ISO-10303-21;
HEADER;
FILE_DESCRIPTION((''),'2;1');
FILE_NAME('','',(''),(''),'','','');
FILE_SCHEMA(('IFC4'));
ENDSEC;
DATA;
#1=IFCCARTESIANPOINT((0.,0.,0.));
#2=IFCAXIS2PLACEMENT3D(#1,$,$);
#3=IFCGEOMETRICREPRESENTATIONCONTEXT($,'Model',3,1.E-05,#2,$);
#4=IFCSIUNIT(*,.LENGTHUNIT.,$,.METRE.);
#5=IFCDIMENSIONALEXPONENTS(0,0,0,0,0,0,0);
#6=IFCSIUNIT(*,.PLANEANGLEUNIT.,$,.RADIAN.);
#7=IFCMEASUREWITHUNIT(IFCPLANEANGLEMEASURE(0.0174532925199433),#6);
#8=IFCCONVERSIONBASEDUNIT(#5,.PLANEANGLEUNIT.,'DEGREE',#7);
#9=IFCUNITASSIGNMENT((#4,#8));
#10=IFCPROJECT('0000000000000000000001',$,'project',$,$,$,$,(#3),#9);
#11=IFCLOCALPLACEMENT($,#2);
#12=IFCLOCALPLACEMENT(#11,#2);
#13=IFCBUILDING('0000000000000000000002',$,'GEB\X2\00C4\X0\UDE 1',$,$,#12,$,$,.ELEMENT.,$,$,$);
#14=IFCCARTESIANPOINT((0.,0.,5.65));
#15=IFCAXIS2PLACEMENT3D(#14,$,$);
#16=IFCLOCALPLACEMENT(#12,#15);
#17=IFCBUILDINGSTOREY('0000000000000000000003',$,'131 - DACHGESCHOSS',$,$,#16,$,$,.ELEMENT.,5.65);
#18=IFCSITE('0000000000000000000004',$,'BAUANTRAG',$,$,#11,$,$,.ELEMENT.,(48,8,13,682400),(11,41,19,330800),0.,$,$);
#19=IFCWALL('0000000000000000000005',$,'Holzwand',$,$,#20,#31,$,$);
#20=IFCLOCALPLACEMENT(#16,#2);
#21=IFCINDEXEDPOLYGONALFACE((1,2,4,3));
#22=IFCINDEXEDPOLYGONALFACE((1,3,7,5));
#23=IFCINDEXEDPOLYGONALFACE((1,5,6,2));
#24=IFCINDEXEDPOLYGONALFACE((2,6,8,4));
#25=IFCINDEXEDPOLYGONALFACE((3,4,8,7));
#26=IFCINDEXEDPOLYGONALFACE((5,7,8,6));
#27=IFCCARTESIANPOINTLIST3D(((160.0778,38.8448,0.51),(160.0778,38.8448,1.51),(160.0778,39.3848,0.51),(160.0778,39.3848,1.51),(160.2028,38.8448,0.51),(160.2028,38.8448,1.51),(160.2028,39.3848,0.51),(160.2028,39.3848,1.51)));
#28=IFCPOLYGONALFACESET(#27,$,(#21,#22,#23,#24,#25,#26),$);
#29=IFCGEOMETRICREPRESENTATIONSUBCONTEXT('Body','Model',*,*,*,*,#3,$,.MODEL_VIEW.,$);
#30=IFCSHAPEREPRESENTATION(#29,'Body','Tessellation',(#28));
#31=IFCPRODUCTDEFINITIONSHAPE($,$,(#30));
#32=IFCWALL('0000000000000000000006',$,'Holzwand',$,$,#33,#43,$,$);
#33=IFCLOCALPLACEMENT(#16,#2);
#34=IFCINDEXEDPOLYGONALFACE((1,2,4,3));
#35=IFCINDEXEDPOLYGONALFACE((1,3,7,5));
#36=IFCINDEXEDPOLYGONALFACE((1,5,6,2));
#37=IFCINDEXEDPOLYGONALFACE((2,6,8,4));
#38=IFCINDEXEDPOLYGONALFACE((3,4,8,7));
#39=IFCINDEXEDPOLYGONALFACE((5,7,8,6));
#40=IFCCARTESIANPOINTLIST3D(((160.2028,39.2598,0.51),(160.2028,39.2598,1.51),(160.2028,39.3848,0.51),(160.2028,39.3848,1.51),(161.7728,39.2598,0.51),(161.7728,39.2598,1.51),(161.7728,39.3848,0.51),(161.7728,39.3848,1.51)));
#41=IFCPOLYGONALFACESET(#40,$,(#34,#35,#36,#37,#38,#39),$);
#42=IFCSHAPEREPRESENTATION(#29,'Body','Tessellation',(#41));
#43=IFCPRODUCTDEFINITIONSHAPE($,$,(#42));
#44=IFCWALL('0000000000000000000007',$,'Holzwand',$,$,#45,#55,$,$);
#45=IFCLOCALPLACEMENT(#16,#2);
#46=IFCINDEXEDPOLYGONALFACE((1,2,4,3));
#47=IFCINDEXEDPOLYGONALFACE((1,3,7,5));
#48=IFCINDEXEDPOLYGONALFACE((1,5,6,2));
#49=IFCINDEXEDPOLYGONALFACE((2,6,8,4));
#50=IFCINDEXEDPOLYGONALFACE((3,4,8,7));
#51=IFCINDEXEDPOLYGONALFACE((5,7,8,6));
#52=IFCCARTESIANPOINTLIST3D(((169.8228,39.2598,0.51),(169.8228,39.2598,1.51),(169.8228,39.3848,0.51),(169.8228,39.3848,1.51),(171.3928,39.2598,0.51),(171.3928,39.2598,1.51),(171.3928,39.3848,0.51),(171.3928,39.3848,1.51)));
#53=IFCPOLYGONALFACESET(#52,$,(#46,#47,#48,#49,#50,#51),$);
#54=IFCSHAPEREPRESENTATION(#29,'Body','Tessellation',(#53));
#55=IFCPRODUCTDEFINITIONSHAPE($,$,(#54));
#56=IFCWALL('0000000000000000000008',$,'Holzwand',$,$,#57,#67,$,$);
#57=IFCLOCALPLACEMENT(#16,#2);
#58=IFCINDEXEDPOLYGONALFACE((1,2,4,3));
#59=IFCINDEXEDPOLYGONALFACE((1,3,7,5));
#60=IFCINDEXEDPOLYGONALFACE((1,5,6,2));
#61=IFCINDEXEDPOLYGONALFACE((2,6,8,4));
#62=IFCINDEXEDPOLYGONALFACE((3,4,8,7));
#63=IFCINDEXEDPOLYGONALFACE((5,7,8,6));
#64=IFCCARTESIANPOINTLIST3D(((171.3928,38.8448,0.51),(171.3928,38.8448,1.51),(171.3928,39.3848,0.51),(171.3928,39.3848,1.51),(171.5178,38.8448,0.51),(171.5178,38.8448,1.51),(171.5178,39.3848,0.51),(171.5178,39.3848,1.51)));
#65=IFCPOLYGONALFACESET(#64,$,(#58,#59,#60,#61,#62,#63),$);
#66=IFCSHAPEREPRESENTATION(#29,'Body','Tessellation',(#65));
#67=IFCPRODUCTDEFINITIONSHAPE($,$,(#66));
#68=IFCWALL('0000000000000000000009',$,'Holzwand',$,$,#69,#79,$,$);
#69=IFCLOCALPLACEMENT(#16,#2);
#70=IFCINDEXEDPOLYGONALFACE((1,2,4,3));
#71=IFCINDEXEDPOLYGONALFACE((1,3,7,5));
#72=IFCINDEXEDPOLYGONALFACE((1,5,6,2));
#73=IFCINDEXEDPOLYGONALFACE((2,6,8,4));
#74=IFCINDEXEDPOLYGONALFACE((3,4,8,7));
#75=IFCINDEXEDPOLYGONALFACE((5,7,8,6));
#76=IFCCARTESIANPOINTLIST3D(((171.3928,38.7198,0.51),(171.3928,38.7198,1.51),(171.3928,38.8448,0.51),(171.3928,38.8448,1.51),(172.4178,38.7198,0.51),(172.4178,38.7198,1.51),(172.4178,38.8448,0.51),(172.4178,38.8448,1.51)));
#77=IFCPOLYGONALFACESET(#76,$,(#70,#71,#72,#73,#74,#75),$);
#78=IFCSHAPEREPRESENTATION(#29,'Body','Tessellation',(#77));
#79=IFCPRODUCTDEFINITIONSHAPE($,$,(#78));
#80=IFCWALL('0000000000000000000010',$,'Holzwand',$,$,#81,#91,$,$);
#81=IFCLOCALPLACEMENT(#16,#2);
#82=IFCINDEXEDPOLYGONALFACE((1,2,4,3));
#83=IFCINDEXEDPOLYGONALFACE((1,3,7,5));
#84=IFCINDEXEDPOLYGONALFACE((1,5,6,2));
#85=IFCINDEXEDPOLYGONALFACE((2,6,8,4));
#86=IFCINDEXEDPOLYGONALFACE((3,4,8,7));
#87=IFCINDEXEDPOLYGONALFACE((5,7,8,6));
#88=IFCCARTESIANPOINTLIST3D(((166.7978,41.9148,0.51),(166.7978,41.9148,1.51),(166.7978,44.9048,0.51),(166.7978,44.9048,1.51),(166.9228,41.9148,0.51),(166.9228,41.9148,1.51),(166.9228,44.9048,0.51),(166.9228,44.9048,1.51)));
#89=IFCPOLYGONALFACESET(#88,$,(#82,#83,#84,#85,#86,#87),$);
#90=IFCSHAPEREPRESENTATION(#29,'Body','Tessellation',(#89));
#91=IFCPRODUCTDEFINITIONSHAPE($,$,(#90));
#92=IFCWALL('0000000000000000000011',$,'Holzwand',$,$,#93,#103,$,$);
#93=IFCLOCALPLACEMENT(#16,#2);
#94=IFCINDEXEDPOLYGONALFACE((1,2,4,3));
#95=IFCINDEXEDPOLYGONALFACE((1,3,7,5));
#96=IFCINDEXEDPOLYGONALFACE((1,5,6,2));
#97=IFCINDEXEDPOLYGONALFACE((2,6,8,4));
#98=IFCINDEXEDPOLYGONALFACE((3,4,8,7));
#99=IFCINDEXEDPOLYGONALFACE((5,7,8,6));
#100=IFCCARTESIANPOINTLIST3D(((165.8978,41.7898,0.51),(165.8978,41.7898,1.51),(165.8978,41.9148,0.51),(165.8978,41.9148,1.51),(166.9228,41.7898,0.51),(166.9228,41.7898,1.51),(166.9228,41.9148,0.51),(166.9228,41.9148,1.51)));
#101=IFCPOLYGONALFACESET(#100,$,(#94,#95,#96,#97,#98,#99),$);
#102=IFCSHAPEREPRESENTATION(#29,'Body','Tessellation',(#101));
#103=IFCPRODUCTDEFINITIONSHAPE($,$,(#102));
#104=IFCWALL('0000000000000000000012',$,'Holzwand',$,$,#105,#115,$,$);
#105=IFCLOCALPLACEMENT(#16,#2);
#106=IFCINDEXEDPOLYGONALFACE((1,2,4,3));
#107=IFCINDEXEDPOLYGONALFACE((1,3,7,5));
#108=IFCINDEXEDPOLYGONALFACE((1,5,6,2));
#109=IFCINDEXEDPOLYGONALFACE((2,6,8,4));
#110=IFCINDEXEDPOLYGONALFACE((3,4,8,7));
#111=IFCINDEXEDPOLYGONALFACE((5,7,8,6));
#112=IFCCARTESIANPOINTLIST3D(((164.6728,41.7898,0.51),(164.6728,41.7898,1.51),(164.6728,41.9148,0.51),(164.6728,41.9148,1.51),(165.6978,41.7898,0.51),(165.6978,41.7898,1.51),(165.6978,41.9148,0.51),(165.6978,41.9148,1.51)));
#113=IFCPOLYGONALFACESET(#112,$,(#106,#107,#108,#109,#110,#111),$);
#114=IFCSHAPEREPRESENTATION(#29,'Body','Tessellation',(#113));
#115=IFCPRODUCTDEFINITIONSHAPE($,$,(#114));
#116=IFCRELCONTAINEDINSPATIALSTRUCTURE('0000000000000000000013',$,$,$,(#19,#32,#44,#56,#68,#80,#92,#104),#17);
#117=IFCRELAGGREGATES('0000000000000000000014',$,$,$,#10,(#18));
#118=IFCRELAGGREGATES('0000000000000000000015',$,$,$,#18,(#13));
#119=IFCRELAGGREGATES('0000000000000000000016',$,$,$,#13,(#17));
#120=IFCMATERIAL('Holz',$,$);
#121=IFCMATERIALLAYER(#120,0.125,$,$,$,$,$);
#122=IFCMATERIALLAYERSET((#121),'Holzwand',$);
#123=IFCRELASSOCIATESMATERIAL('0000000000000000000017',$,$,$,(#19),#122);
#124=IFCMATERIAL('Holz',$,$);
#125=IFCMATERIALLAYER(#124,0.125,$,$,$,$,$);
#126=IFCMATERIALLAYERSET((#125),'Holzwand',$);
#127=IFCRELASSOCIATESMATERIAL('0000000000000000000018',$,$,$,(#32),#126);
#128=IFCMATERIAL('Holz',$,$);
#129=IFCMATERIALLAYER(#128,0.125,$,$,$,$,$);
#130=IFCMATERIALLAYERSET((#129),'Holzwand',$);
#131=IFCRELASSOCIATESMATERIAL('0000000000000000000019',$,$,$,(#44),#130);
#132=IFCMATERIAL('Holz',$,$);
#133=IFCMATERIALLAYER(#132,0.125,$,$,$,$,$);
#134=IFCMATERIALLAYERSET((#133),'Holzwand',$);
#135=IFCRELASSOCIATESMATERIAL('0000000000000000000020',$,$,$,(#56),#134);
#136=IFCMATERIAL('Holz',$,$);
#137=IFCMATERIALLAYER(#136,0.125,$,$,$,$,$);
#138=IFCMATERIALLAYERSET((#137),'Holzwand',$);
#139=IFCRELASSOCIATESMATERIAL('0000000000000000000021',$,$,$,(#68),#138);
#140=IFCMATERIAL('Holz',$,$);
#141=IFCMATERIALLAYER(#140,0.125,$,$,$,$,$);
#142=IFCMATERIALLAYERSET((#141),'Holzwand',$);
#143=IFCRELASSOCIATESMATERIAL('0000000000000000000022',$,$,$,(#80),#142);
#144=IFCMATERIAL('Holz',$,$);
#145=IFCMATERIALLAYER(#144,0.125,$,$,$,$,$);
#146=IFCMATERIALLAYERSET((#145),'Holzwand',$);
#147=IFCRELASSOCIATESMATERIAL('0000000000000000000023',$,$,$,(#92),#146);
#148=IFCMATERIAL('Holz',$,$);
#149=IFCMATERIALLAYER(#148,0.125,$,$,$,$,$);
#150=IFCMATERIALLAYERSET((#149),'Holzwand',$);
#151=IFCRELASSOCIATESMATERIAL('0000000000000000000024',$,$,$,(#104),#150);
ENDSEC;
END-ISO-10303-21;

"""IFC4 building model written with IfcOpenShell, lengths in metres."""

from ifc_helpers import new_model, entity, si_unit, converted_unit, frame, frame_2d, origin, origin_with_axes, place, context, subcontext, project, spatial, rectangle, extrude, material, layer, layer_set, layer_usage, element, save


model = new_model("IFC4")

# Units and contexts
model_context = context("Model", 3, precision=1e-05, world=origin())
body_context = subcontext(model_context, "Body", "Model", "MODEL_VIEW")
ifc_project = project(units=[si_unit("LENGTHUNIT", "METRE"), converted_unit("PLANEANGLEUNIT", "DEGREE", entity("IfcPlaneAngleMeasure", 0.0174532925199433), si_unit("PLANEANGLEUNIT", "RADIAN"), dimensions=[0, 0, 0, 0, 0, 0, 0])], contexts=[model_context])

# Site, building, storey
site_placement = place(None, origin())
site = spatial("IfcSite", under=ifc_project, at=site_placement, Name="BAUANTRAG", CompositionType="ELEMENT", RefLatitude=(48, 8, 13, 682400), RefLongitude=(11, 41, 19, 330800), RefElevation=0.0)
building_placement = place(site_placement, origin())
building = spatial("IfcBuilding", under=site, at=building_placement, Name="GEBÄUDE 1", CompositionType="ELEMENT")
storey_placement = place(building_placement, frame((0.0, 0.0, 5.65)))
storey = spatial("IfcBuildingStorey", under=building, at=storey_placement, Name="131 - DACHGESCHOSS", CompositionType="ELEMENT", Elevation=5.65)

# Walls
ifc_material_1 = material(Name="Holz")
ifc_layer_1 = layer(ifc_material_1, 0.125)
ifc_layer_set_1 = layer_set([ifc_layer_1], Name="Holzwand")
ifc_layer_usage_1 = layer_usage(ifc_layer_set_1, "AXIS2", "POSITIVE", 0.0)
wall_1_placement = place(storey_placement, frame((160.0778, 39.3848, 0.51), z_axis=(0.0, 0.0, 1.0), x_axis=(0.0, -1.0, 0.0)))
element("IfcWall", 1, at=wall_1_placement, inside=storey, material=ifc_layer_usage_1, Name="Holzwand", context=body_context, shape_type="SweptSolid", body=[
    extrude(rectangle(XDim=0.54, YDim=0.125, at=frame_2d((0.27, 0.0625), x_axis=(1.0, 0.0))), origin_with_axes(), (0.0, 0.0, 1.0), 1.0),
])
ifc_material_2 = material(Name="Holz")
ifc_layer_2 = layer(ifc_material_2, 0.125)
ifc_layer_set_2 = layer_set([ifc_layer_2], Name="Holzwand")
ifc_layer_usage_2 = layer_usage(ifc_layer_set_2, "AXIS2", "POSITIVE", 0.0)
wall_2_placement = place(storey_placement, frame((161.7728, 39.3848, 0.51), z_axis=(0.0, 0.0, 1.0), x_axis=(-1.0, 0.0, 0.0)))
element("IfcWall", 2, at=wall_2_placement, inside=storey, material=ifc_layer_usage_2, Name="Holzwand", context=body_context, shape_type="SweptSolid", body=[
    extrude(rectangle(XDim=1.57, YDim=0.125, at=frame_2d((0.785, 0.0625), x_axis=(1.0, 0.0))), origin_with_axes(), (0.0, 0.0, 1.0), 1.0),
])
ifc_material_3 = material(Name="Holz")
ifc_layer_3 = layer(ifc_material_3, 0.125)
ifc_layer_set_3 = layer_set([ifc_layer_3], Name="Holzwand")
ifc_layer_usage_3 = layer_usage(ifc_layer_set_3, "AXIS2", "POSITIVE", 0.0)
wall_3_placement = place(storey_placement, frame((171.3928, 39.3848, 0.51), z_axis=(0.0, 0.0, 1.0), x_axis=(-1.0, 0.0, 0.0)))
element("IfcWall", 3, at=wall_3_placement, inside=storey, material=ifc_layer_usage_3, Name="Holzwand", context=body_context, shape_type="SweptSolid", body=[
    extrude(rectangle(XDim=1.57, YDim=0.125, at=frame_2d((0.785, 0.0625), x_axis=(1.0, 0.0))), origin_with_axes(), (0.0, 0.0, 1.0), 1.0),
])
ifc_material_4 = material(Name="Holz")
ifc_layer_4 = layer(ifc_material_4, 0.125)
ifc_layer_set_4 = layer_set([ifc_layer_4], Name="Holzwand")
ifc_layer_usage_4 = layer_usage(ifc_layer_set_4, "AXIS2", "POSITIVE", 0.0)
wall_4_placement = place(storey_placement, frame((171.5178, 38.8448, 0.51), z_axis=(0.0, 0.0, 1.0), x_axis=(0.0, 1.0, 0.0)))
element("IfcWall", 4, at=wall_4_placement, inside=storey, material=ifc_layer_usage_4, Name="Holzwand", context=body_context, shape_type="SweptSolid", body=[
    extrude(rectangle(XDim=0.54, YDim=0.125, at=frame_2d((0.27, 0.0625), x_axis=(1.0, 0.0))), origin_with_axes(), (0.0, 0.0, 1.0), 1.0),
])
ifc_material_5 = material(Name="Holz")
ifc_layer_5 = layer(ifc_material_5, 0.125)
ifc_layer_set_5 = layer_set([ifc_layer_5], Name="Holzwand")
ifc_layer_usage_5 = layer_usage(ifc_layer_set_5, "AXIS2", "POSITIVE", 0.0)
wall_5_placement = place(storey_placement, frame((172.4178, 38.8448, 0.51), z_axis=(0.0, 0.0, 1.0), x_axis=(-1.0, 0.0, 0.0)))
element("IfcWall", 5, at=wall_5_placement, inside=storey, material=ifc_layer_usage_5, Name="Holzwand", context=body_context, shape_type="SweptSolid", body=[
    extrude(rectangle(XDim=1.025, YDim=0.125, at=frame_2d((0.5125, 0.0625), x_axis=(1.0, 0.0))), origin_with_axes(), (0.0, 0.0, 1.0), 1.0),
])
ifc_material_6 = material(Name="Holz")
ifc_layer_6 = layer(ifc_material_6, 0.125)
ifc_layer_set_6 = layer_set([ifc_layer_6], Name="Holzwand")
ifc_layer_usage_6 = layer_usage(ifc_layer_set_6, "AXIS2", "POSITIVE", 0.0)
wall_6_placement = place(storey_placement, frame((166.7978, 44.9048, 0.51), z_axis=(0.0, 0.0, 1.0), x_axis=(0.0, -1.0, 0.0)))
element("IfcWall", 6, at=wall_6_placement, inside=storey, material=ifc_layer_usage_6, Name="Holzwand", context=body_context, shape_type="SweptSolid", body=[
    extrude(rectangle(XDim=2.99, YDim=0.125, at=frame_2d((1.495, 0.0625), x_axis=(1.0, 0.0))), origin_with_axes(), (0.0, 0.0, 1.0), 1.0),
])
ifc_material_7 = material(Name="Holz")
ifc_layer_7 = layer(ifc_material_7, 0.125)
ifc_layer_set_7 = layer_set([ifc_layer_7], Name="Holzwand")
ifc_layer_usage_7 = layer_usage(ifc_layer_set_7, "AXIS2", "POSITIVE", 0.0)
wall_7_placement = place(storey_placement, frame((166.9228, 41.9148, 0.51), z_axis=(0.0, 0.0, 1.0), x_axis=(-1.0, 0.0, 0.0)))
element("IfcWall", 7, at=wall_7_placement, inside=storey, material=ifc_layer_usage_7, Name="Holzwand", context=body_context, shape_type="SweptSolid", body=[
    extrude(rectangle(XDim=1.025, YDim=0.125, at=frame_2d((0.5125, 0.0625), x_axis=(1.0, 0.0))), origin_with_axes(), (0.0, 0.0, 1.0), 1.0),
])
ifc_material_8 = material(Name="Holz")
ifc_layer_8 = layer(ifc_material_8, 0.125)
ifc_layer_set_8 = layer_set([ifc_layer_8], Name="Holzwand")
ifc_layer_usage_8 = layer_usage(ifc_layer_set_8, "AXIS2", "POSITIVE", 0.0)
wall_8_placement = place(storey_placement, frame((165.6978, 41.9148, 0.51), z_axis=(0.0, 0.0, 1.0), x_axis=(-1.0, 0.0, 0.0)))
element("IfcWall", 8, at=wall_8_placement, inside=storey, material=ifc_layer_usage_8, Name="Holzwand", context=body_context, shape_type="SweptSolid", body=[
    extrude(rectangle(XDim=1.025, YDim=0.125, at=frame_2d((0.5125, 0.0625), x_axis=(1.0, 0.0))), origin_with_axes(), (0.0, 0.0, 1.0), 1.0),
])

save(model, "model.ifc")
